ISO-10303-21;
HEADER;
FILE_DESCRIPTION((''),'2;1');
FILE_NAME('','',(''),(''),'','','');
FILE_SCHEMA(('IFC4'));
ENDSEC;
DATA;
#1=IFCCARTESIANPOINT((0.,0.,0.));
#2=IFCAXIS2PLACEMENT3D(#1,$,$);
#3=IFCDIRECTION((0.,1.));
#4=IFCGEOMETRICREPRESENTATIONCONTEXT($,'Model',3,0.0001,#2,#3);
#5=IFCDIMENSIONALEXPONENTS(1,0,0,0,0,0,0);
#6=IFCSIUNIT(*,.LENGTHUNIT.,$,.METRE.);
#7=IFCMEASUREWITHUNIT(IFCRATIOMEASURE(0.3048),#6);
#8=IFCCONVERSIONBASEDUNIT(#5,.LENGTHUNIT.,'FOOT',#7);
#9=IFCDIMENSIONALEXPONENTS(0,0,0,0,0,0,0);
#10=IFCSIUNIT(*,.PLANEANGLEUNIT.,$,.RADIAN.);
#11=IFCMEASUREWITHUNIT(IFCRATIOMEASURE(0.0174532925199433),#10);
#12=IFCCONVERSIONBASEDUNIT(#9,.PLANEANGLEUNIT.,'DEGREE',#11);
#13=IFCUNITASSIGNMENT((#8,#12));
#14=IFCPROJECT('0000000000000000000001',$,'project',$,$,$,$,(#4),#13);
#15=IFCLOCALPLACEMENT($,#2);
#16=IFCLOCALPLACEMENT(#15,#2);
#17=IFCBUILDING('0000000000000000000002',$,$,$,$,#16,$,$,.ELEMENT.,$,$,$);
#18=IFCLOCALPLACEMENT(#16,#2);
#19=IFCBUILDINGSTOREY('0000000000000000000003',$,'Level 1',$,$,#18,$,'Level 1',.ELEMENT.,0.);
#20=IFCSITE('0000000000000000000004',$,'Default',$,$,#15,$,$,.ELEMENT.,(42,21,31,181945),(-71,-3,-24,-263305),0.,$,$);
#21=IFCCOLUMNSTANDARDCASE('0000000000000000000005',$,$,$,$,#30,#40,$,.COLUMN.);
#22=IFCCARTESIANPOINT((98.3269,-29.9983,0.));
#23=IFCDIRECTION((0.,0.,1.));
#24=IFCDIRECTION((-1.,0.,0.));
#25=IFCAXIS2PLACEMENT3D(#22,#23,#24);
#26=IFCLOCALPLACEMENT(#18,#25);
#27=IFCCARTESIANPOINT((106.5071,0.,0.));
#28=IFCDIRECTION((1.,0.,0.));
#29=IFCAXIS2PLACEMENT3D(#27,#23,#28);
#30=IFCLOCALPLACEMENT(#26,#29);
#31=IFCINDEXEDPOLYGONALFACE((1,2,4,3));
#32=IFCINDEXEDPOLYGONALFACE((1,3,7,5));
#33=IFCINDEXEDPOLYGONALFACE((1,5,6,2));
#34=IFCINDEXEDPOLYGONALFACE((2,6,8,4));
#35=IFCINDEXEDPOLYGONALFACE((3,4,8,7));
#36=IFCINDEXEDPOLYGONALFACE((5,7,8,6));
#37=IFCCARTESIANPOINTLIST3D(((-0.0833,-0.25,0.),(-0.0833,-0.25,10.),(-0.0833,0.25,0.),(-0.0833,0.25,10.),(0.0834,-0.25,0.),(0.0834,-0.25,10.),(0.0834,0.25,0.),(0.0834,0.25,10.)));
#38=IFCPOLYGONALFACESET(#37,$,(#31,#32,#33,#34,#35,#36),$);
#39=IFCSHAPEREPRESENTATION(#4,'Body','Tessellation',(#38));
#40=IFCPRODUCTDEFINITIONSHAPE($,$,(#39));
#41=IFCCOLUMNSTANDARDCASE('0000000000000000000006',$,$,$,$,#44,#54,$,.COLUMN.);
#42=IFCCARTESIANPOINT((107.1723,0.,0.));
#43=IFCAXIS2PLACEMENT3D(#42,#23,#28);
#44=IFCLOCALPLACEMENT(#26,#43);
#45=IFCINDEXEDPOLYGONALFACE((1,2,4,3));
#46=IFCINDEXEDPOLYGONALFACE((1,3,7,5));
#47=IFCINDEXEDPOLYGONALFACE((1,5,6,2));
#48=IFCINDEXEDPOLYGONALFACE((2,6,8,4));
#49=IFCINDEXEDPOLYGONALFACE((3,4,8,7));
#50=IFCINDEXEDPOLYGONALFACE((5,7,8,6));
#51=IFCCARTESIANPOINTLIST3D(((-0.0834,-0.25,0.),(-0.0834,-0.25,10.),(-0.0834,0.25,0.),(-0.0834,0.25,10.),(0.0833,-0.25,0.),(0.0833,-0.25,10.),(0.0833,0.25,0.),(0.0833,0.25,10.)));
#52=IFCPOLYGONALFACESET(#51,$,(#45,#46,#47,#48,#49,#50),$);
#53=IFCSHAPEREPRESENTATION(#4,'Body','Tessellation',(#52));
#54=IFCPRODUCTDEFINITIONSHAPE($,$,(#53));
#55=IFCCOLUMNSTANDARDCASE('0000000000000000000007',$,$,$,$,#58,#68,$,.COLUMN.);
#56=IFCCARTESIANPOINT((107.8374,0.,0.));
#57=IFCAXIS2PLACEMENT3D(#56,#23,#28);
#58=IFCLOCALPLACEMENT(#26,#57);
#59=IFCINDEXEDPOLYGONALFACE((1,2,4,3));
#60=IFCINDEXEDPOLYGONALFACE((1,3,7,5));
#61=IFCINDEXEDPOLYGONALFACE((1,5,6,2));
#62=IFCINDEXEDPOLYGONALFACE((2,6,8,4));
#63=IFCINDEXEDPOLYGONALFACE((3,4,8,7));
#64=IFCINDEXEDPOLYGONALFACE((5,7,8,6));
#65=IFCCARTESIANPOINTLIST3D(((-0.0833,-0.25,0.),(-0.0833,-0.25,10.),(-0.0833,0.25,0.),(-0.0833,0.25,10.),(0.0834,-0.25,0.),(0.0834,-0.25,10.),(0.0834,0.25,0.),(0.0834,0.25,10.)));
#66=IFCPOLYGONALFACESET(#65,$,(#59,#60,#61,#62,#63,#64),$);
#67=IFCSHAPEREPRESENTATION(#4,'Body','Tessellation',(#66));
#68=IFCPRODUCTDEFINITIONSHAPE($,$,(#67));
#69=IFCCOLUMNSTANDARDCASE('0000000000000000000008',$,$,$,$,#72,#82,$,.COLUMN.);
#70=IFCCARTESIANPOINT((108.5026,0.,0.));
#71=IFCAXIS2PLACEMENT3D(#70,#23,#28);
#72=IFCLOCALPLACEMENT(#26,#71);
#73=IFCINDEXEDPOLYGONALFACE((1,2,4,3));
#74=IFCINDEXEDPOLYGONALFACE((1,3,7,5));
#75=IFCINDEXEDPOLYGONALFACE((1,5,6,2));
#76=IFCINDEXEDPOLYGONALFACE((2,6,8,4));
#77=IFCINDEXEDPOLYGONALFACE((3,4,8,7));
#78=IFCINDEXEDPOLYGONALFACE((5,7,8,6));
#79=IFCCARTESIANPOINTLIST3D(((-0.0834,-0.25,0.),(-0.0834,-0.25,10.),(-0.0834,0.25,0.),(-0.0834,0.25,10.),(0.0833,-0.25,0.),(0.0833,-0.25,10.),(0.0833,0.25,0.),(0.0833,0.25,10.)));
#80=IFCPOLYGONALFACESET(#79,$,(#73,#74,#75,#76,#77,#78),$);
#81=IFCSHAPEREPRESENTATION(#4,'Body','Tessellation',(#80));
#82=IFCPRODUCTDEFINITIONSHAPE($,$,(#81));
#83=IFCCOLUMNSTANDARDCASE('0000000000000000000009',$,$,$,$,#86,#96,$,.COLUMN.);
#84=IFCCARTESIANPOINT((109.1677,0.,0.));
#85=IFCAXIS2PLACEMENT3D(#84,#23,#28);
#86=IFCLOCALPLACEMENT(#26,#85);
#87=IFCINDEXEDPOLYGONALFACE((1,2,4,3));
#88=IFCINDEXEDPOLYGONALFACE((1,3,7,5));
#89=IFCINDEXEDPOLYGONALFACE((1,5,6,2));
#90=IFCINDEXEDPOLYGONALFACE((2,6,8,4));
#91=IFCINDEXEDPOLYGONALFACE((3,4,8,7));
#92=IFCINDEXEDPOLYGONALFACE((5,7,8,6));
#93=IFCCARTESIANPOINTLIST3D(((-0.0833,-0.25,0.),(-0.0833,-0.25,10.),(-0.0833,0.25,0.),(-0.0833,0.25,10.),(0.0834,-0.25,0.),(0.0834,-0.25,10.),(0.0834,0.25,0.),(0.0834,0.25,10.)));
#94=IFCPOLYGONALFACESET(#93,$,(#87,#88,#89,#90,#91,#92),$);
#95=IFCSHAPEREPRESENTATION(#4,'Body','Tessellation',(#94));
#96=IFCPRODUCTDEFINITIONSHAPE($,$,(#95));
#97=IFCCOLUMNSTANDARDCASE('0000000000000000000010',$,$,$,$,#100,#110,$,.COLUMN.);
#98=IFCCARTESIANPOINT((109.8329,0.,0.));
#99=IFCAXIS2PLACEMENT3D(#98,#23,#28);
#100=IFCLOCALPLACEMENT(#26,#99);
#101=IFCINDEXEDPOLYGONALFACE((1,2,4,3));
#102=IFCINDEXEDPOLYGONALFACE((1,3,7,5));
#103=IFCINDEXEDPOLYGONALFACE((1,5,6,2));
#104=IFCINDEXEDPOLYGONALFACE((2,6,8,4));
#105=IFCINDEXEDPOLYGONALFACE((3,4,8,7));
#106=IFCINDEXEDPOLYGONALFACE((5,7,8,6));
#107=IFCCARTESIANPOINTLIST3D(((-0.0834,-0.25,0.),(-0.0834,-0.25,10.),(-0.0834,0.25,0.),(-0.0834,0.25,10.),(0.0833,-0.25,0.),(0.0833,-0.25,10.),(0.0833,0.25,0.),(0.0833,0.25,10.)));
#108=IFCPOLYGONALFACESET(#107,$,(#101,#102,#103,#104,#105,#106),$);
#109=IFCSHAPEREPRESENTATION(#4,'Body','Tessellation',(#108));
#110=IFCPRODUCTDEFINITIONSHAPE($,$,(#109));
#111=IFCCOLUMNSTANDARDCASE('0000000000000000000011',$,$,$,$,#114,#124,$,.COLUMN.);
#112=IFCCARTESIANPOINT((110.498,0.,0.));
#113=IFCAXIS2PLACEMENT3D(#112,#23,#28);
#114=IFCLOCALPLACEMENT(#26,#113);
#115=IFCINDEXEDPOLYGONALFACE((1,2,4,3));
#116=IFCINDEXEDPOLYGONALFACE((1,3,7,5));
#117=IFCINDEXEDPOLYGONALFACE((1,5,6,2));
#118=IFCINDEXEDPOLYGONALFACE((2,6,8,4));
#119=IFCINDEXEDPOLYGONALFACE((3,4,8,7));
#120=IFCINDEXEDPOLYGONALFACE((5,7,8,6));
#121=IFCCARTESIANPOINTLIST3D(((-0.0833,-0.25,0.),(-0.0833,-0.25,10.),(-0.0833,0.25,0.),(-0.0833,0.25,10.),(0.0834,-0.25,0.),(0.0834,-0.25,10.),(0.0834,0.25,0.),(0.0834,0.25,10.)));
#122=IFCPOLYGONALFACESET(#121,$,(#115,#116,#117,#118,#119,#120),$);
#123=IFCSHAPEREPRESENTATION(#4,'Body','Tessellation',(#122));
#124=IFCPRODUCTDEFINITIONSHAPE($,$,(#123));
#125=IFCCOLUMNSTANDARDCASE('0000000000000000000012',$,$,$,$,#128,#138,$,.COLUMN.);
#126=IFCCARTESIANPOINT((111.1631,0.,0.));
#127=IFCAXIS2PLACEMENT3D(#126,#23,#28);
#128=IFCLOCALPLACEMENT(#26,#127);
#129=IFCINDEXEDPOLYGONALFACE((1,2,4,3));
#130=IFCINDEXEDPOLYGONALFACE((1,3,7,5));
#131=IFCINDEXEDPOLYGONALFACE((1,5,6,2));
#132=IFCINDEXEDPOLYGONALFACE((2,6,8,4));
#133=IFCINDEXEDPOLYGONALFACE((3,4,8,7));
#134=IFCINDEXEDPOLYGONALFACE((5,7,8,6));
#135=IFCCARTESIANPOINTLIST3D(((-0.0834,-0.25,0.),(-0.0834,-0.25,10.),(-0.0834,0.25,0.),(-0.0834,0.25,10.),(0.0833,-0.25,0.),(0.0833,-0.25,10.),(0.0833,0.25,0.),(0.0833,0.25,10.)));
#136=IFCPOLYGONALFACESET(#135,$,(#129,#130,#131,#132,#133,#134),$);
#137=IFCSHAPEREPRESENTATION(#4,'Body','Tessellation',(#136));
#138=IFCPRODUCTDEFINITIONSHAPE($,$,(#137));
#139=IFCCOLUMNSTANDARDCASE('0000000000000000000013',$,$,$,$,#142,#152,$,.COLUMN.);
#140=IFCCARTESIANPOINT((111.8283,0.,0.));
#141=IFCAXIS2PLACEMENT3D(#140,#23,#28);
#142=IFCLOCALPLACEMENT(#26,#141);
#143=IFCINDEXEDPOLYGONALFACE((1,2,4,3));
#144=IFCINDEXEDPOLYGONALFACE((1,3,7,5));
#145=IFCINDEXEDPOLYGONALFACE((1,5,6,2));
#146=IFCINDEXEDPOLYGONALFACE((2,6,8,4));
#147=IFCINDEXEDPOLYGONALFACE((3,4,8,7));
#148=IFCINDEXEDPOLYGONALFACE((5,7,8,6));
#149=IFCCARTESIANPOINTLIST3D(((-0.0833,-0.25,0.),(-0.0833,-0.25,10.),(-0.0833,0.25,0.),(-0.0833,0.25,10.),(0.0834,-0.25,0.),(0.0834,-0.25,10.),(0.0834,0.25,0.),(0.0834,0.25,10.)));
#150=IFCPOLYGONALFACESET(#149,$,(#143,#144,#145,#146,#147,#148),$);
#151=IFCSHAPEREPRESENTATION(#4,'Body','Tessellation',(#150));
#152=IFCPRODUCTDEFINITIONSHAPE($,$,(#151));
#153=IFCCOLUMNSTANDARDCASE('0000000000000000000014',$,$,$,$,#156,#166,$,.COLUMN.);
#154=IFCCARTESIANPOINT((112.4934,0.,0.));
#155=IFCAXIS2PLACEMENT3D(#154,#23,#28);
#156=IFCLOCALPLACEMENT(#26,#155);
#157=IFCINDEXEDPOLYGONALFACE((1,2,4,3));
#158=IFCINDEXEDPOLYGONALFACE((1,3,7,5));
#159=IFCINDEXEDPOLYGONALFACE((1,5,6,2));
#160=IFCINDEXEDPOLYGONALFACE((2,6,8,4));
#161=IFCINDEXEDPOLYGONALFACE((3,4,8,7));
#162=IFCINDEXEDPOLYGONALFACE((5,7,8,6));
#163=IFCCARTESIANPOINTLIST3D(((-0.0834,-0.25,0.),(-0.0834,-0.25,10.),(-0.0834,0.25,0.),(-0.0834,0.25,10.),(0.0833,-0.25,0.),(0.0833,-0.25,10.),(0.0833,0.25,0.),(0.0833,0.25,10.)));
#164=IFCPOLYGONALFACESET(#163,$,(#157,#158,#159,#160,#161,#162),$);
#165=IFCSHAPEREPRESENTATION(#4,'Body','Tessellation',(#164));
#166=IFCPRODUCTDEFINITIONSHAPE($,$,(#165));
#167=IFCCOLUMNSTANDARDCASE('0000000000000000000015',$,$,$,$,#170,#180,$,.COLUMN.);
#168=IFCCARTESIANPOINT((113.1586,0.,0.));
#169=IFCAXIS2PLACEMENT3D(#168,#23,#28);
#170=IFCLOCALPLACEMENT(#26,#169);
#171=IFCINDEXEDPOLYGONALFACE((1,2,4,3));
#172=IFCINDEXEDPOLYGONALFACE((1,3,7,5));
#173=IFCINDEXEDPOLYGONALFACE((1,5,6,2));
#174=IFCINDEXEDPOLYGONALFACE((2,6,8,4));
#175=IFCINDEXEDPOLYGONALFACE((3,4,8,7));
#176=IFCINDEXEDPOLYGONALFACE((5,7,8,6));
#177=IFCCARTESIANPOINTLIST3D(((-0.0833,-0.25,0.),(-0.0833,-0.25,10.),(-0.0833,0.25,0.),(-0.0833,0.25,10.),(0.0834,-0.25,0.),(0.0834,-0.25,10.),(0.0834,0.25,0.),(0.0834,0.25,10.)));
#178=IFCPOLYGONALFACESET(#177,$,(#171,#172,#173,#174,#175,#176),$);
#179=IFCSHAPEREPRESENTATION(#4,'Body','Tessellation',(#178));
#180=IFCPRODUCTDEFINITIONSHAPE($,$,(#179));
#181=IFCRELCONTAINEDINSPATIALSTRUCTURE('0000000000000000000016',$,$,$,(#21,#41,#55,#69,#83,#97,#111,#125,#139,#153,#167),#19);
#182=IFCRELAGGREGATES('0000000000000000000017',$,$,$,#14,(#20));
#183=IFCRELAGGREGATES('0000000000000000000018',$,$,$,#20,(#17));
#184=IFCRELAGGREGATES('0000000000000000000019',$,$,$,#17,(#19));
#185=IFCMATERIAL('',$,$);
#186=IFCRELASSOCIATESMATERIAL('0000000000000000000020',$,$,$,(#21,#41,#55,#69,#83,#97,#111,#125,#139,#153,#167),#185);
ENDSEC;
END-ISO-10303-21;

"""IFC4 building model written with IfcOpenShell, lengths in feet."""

from ifc_helpers import new_model, entity, si_unit, converted_unit, direction, frame, origin, place, context, project, spatial, rectangle, extrude, material, element, save


model = new_model("IFC4")

# Units and contexts
model_context = context("Model", 3, precision=0.0001, world=origin(), true_north=direction((0.0, 1.0)))
ifc_project = project(units=[converted_unit("LENGTHUNIT", "FOOT", entity("IfcRatioMeasure", 0.3048), si_unit("LENGTHUNIT", "METRE"), dimensions=[1, 0, 0, 0, 0, 0, 0]), converted_unit("PLANEANGLEUNIT", "DEGREE", entity("IfcRatioMeasure", 0.0174532925199433), si_unit("PLANEANGLEUNIT", "RADIAN"), dimensions=[0, 0, 0, 0, 0, 0, 0])], contexts=[model_context])

# Site, building, storey
site_placement = place(None, origin())
site = spatial("IfcSite", under=ifc_project, at=site_placement, Name="Default", CompositionType="ELEMENT", RefLatitude=(42, 21, 31, 181945), RefLongitude=(-71, -3, -24, -263305), RefElevation=0.0)
building_placement = place(site_placement, origin())
building = spatial("IfcBuilding", under=site, at=building_placement, CompositionType="ELEMENT")
storey_placement = place(building_placement, origin())
storey = spatial("IfcBuildingStorey", under=building, at=storey_placement, Name="Level 1", LongName="Level 1", CompositionType="ELEMENT", Elevation=0.0)

# Columns
ifc_material = material(Name="")
placement = place(storey_placement, frame((98.3269, -29.9983, 0.0), z_axis=(0.0, 0.0, 1.0), x_axis=(-1.0, 0.0, 0.0)))
for number, where, z_axis, x_axis in (
    (1, (106.5071, 0.0, 0.0), (0.0, 0.0, 1.0), (1.0, 0.0, 0.0)),
    (2, (107.1723, 0.0, 0.0), (0.0, 0.0, 1.0), (1.0, 0.0, 0.0)),
    (3, (107.8374, 0.0, 0.0), (0.0, 0.0, 1.0), (1.0, 0.0, 0.0)),
    (4, (108.5026, 0.0, 0.0), (0.0, 0.0, 1.0), (1.0, 0.0, 0.0)),
    (5, (109.1677, 0.0, 0.0), (0.0, 0.0, 1.0), (1.0, 0.0, 0.0)),
    (6, (109.8329, 0.0, 0.0), (0.0, 0.0, 1.0), (1.0, 0.0, 0.0)),
    (7, (110.498, 0.0, 0.0), (0.0, 0.0, 1.0), (1.0, 0.0, 0.0)),
    (8, (111.1631, 0.0, 0.0), (0.0, 0.0, 1.0), (1.0, 0.0, 0.0)),
    (9, (111.8283, 0.0, 0.0), (0.0, 0.0, 1.0), (1.0, 0.0, 0.0)),
    (10, (112.4934, 0.0, 0.0), (0.0, 0.0, 1.0), (1.0, 0.0, 0.0)),
    (11, (113.1586, 0.0, 0.0), (0.0, 0.0, 1.0), (1.0, 0.0, 0.0)),
):
    element("IfcColumnStandardCase", number, at=place(placement, frame(where, z_axis=z_axis, x_axis=x_axis)), inside=storey, material=ifc_material, PredefinedType="COLUMN", context=model_context, shape_type="SweptSolid", body=[
        extrude(rectangle(XDim=0.1667, YDim=0.5), origin(), (0.0, 0.0, 1.0), 10.0),
    ])

save(model, "model.ifc")
